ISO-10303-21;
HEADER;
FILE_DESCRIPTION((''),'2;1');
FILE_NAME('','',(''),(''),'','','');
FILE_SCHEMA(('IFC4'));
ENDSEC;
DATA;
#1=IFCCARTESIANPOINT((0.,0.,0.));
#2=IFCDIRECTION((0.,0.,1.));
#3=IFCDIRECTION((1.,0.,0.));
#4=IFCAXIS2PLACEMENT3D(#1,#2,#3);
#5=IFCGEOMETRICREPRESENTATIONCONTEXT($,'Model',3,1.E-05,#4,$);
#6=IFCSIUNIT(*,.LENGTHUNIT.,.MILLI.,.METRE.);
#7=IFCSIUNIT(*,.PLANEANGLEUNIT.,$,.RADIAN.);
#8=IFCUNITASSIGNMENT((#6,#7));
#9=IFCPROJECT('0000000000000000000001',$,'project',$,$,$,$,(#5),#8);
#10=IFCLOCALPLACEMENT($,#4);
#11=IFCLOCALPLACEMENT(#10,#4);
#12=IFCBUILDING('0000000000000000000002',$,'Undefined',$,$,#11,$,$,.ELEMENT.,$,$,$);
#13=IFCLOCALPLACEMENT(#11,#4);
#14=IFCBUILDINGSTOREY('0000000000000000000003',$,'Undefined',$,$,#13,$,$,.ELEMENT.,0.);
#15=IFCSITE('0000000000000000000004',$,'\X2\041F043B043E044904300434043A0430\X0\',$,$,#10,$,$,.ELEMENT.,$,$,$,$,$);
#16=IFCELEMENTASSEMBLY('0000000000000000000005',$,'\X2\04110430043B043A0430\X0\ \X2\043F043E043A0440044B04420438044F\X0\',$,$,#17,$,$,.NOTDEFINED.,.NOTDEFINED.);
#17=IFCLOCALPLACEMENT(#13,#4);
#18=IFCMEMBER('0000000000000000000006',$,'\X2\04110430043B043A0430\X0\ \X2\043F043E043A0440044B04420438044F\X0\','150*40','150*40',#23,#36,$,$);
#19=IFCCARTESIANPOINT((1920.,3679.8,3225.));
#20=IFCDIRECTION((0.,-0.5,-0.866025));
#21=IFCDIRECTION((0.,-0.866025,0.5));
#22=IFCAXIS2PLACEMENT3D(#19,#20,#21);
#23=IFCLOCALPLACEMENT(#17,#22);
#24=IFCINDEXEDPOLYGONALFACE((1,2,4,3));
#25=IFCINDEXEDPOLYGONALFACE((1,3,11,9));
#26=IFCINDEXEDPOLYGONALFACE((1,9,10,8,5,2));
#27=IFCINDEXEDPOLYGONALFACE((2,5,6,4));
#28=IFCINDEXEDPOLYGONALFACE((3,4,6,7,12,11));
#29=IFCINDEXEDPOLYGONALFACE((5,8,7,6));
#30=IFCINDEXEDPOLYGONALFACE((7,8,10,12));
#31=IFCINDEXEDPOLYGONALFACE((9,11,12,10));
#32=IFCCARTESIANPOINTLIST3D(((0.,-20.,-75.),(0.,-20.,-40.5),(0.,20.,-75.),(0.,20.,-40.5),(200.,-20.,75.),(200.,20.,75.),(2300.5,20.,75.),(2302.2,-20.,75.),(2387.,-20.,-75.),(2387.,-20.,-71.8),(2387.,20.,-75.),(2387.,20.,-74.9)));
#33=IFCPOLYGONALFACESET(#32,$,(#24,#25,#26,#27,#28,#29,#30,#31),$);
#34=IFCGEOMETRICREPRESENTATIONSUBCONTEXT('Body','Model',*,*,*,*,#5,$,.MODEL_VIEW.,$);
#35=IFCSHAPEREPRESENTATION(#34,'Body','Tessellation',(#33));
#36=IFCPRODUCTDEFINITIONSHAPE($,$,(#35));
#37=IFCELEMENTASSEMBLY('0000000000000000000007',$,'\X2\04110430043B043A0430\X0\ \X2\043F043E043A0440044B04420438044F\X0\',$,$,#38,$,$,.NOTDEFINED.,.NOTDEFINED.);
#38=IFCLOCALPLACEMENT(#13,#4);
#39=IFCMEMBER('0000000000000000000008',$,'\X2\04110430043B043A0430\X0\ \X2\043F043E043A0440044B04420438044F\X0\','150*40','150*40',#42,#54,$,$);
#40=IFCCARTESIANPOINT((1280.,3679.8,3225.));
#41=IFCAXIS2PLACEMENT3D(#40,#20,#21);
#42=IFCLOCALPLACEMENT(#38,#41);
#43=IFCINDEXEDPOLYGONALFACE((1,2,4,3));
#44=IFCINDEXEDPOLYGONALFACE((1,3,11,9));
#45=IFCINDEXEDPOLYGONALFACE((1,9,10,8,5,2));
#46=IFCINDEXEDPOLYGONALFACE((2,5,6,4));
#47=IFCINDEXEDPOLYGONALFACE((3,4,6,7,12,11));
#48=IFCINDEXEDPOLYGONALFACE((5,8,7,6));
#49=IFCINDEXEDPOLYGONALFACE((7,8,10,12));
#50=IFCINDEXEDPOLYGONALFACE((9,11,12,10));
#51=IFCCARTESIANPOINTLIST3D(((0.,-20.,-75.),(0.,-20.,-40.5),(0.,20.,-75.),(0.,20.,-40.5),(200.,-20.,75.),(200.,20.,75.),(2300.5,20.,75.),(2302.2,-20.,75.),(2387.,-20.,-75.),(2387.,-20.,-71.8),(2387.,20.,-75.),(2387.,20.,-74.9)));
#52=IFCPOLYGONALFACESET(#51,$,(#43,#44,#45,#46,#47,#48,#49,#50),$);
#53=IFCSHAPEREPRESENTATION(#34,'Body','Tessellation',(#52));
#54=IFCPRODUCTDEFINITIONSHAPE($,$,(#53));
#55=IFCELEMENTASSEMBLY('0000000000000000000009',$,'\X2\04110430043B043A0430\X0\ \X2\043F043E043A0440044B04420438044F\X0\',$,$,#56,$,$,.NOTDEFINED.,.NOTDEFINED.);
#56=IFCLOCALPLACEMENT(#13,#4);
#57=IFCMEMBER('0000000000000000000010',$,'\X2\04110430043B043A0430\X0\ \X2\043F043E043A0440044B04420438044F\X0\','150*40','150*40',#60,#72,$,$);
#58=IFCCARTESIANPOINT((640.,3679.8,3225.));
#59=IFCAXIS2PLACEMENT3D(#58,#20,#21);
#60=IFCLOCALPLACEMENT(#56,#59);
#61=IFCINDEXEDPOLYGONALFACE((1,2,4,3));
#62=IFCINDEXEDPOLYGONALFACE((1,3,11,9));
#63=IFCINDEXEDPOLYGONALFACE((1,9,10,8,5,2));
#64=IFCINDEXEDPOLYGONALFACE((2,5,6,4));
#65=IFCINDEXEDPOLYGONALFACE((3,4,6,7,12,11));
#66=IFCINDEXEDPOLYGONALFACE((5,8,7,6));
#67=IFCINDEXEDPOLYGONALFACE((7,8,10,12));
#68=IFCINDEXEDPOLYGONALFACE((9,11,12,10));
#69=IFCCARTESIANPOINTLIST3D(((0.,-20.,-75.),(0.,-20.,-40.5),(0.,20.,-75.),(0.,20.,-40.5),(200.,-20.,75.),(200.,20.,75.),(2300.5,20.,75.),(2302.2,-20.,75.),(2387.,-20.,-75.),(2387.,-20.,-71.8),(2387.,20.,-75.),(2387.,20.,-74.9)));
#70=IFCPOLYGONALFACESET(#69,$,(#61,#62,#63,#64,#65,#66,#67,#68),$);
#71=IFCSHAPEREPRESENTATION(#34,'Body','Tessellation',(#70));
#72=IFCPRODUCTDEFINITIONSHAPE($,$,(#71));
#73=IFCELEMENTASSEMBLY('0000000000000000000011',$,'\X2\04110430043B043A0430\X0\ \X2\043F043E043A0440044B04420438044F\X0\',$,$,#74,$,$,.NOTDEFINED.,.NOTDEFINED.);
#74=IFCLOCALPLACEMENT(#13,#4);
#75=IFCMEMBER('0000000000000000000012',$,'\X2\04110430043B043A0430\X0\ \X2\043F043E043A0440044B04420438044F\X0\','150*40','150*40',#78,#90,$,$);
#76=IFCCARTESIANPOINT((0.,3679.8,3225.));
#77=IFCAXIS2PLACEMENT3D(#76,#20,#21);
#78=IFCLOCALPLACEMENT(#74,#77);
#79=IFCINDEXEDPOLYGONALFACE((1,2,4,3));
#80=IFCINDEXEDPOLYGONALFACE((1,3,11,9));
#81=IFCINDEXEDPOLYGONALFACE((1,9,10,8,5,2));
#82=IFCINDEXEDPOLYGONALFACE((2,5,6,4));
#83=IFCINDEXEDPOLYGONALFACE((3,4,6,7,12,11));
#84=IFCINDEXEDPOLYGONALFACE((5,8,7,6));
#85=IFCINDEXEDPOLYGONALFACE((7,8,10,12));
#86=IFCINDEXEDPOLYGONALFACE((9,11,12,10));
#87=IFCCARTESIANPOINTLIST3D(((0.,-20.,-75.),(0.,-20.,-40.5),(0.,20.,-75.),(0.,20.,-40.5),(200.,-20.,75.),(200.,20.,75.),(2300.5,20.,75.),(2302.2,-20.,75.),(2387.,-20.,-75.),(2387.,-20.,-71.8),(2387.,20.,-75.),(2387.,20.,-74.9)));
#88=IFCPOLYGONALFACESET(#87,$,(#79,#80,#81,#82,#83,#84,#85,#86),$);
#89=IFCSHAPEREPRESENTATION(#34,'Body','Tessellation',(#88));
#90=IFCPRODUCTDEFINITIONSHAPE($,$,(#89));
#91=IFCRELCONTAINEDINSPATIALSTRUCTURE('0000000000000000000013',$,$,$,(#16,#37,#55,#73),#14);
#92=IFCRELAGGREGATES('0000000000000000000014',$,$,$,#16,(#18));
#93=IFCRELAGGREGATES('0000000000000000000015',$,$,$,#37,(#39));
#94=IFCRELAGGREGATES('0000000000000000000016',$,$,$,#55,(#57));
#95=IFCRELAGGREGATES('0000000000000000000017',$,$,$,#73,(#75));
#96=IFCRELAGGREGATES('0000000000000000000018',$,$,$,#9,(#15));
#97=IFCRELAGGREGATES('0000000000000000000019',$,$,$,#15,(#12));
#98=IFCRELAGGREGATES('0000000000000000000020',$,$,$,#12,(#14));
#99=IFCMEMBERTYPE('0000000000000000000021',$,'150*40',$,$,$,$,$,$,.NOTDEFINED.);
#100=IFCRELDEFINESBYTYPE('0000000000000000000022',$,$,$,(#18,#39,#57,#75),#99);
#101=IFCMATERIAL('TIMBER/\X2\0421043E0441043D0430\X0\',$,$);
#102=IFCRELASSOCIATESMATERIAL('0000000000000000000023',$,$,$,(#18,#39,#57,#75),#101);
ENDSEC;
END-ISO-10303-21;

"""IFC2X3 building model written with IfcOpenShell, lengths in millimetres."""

from ifc_helpers import new_model, si_unit, frame, origin_with_axes, origin_2d_with_axis, place, context, subcontext, project, spatial, rectangle, extrude, boolean, halfspace, material, type_object, element, aggregate, save


model = new_model("IFC2X3")

# Units and contexts
model_context = context("Model", 3, precision=1e-05, world=origin_with_axes())
body_context = subcontext(model_context, "Body", "Model", "MODEL_VIEW")
ifc_project = project(units=[si_unit("LENGTHUNIT", "METRE", prefix="MILLI"), si_unit("PLANEANGLEUNIT", "RADIAN")], contexts=[model_context])

# Site, building, storey
site_placement = place(None, origin_with_axes())
site = spatial("IfcSite", under=ifc_project, at=site_placement, Name="Площадка", CompositionType="ELEMENT")
building_placement = place(site_placement, origin_with_axes())
building = spatial("IfcBuilding", under=site, at=building_placement, Name="Undefined", CompositionType="ELEMENT")
storey_placement = place(building_placement, origin_with_axes())
storey = spatial("IfcBuildingStorey", under=building, at=storey_placement, Name="Undefined", CompositionType="ELEMENT", Elevation=0.0)

# Shared definitions
ifc_material = material(Name="TIMBER/Сосна")

# Element assemblies, members
assembly_1_placement = place(storey_placement, origin_with_axes())
assembly_1 = element("IfcElementAssembly", 1, at=assembly_1_placement, inside=storey, Name="Балка покрытия", AssemblyPlace="NOTDEFINED", PredefinedType="NOTDEFINED")
member_type = type_object("IfcMemberType", Name="150*40", PredefinedType="NOTDEFINED")
member_1_placement = place(assembly_1_placement, frame((1920.0, 3679.8, 3225.0), z_axis=(0.0, -0.5, -0.866025), x_axis=(0.0, -0.866025, 0.5)))
member_1 = element("IfcMember", 2, at=member_1_placement, type_object=member_type, material=ifc_material, Name="Балка покрытия", Description="150*40", ObjectType="150*40", context=body_context, shape_type="CSG", body=[
    boolean("DIFFERENCE", boolean("DIFFERENCE", extrude(rectangle(XDim=40.0, YDim=150.0, at=origin_2d_with_axis()), frame((2387.0, 0.0, 0.0), z_axis=(-1.0, 0.0, 0.0), x_axis=(0.0, -1.0, 0.0)), (0.0, 0.0, 1.0), 2387.0), extrude(rectangle(XDim=40.0, YDim=150.0, at=origin_2d_with_axis()), frame((3513.2, 0.0, 2074.5), z_axis=(-0.866025, 0.0, -0.5), x_axis=(0.0, -1.0, 0.0)), (0.0, 0.0, 1.0), 4100.0)), halfspace(frame((2300.5, 20.0, 75.0), z_axis=(0.86539, 0.038305, 0.499633), x_axis=(0.5, 0.0, -0.866025)), False)),
])
aggregate(assembly_1, [member_1])
assembly_2_placement = place(storey_placement, origin_with_axes())
assembly_2 = element("IfcElementAssembly", 3, at=assembly_2_placement, inside=storey, Name="Балка покрытия", AssemblyPlace="NOTDEFINED", PredefinedType="NOTDEFINED")
member_2_placement = place(assembly_2_placement, frame((1280.0, 3679.8, 3225.0), z_axis=(0.0, -0.5, -0.866025), x_axis=(0.0, -0.866025, 0.5)))
member_2 = element("IfcMember", 4, at=member_2_placement, type_object=member_type, material=ifc_material, Name="Балка покрытия", Description="150*40", ObjectType="150*40", context=body_context, shape_type="CSG", body=[
    boolean("DIFFERENCE", boolean("DIFFERENCE", extrude(rectangle(XDim=40.0, YDim=150.0, at=origin_2d_with_axis()), frame((2387.0, 0.0, 0.0), z_axis=(-1.0, 0.0, 0.0), x_axis=(0.0, -1.0, 0.0)), (0.0, 0.0, 1.0), 2387.0), extrude(rectangle(XDim=40.0, YDim=150.0, at=origin_2d_with_axis()), frame((3513.2, 0.0, 2074.5), z_axis=(-0.866025, 0.0, -0.5), x_axis=(0.0, -1.0, 0.0)), (0.0, 0.0, 1.0), 4100.0)), halfspace(frame((2300.5, 20.0, 75.0), z_axis=(0.86539, 0.038305, 0.499633), x_axis=(0.5, 0.0, -0.866025)), False)),
])
aggregate(assembly_2, [member_2])
assembly_3_placement = place(storey_placement, origin_with_axes())
assembly_3 = element("IfcElementAssembly", 5, at=assembly_3_placement, inside=storey, Name="Балка покрытия", AssemblyPlace="NOTDEFINED", PredefinedType="NOTDEFINED")
member_3_placement = place(assembly_3_placement, frame((640.0, 3679.8, 3225.0), z_axis=(0.0, -0.5, -0.866025), x_axis=(0.0, -0.866025, 0.5)))
member_3 = element("IfcMember", 6, at=member_3_placement, type_object=member_type, material=ifc_material, Name="Балка покрытия", Description="150*40", ObjectType="150*40", context=body_context, shape_type="CSG", body=[
    boolean("DIFFERENCE", boolean("DIFFERENCE", extrude(rectangle(XDim=40.0, YDim=150.0, at=origin_2d_with_axis()), frame((2387.0, 0.0, 0.0), z_axis=(-1.0, 0.0, 0.0), x_axis=(0.0, -1.0, 0.0)), (0.0, 0.0, 1.0), 2387.0), extrude(rectangle(XDim=40.0, YDim=150.0, at=origin_2d_with_axis()), frame((3513.2, 0.0, 2074.5), z_axis=(-0.866025, 0.0, -0.5), x_axis=(0.0, -1.0, 0.0)), (0.0, 0.0, 1.0), 4100.0)), halfspace(frame((2300.5, 20.0, 75.0), z_axis=(0.86539, 0.038305, 0.499633), x_axis=(0.5, 0.0, -0.866025)), False)),
])
aggregate(assembly_3, [member_3])
assembly_4_placement = place(storey_placement, origin_with_axes())
assembly_4 = element("IfcElementAssembly", 7, at=assembly_4_placement, inside=storey, Name="Балка покрытия", AssemblyPlace="NOTDEFINED", PredefinedType="NOTDEFINED")
member_4_placement = place(assembly_4_placement, frame((0.0, 3679.8, 3225.0), z_axis=(0.0, -0.5, -0.866025), x_axis=(0.0, -0.866025, 0.5)))
member_4 = element("IfcMember", 8, at=member_4_placement, type_object=member_type, material=ifc_material, Name="Балка покрытия", Description="150*40", ObjectType="150*40", context=body_context, shape_type="CSG", body=[
    boolean("DIFFERENCE", boolean("DIFFERENCE", extrude(rectangle(XDim=40.0, YDim=150.0, at=origin_2d_with_axis()), frame((2387.0, 0.0, 0.0), z_axis=(-1.0, 0.0, 0.0), x_axis=(0.0, -1.0, 0.0)), (0.0, 0.0, 1.0), 2387.0), extrude(rectangle(XDim=40.0, YDim=150.0, at=origin_2d_with_axis()), frame((3513.2, 0.0, 2074.5), z_axis=(-0.866025, 0.0, -0.5), x_axis=(0.0, -1.0, 0.0)), (0.0, 0.0, 1.0), 4100.0)), halfspace(frame((2300.5, 20.0, 75.0), z_axis=(0.86539, 0.038305, 0.499633), x_axis=(0.5, 0.0, -0.866025)), False)),
])
aggregate(assembly_4, [member_4])

save(model, "model.ifc")
